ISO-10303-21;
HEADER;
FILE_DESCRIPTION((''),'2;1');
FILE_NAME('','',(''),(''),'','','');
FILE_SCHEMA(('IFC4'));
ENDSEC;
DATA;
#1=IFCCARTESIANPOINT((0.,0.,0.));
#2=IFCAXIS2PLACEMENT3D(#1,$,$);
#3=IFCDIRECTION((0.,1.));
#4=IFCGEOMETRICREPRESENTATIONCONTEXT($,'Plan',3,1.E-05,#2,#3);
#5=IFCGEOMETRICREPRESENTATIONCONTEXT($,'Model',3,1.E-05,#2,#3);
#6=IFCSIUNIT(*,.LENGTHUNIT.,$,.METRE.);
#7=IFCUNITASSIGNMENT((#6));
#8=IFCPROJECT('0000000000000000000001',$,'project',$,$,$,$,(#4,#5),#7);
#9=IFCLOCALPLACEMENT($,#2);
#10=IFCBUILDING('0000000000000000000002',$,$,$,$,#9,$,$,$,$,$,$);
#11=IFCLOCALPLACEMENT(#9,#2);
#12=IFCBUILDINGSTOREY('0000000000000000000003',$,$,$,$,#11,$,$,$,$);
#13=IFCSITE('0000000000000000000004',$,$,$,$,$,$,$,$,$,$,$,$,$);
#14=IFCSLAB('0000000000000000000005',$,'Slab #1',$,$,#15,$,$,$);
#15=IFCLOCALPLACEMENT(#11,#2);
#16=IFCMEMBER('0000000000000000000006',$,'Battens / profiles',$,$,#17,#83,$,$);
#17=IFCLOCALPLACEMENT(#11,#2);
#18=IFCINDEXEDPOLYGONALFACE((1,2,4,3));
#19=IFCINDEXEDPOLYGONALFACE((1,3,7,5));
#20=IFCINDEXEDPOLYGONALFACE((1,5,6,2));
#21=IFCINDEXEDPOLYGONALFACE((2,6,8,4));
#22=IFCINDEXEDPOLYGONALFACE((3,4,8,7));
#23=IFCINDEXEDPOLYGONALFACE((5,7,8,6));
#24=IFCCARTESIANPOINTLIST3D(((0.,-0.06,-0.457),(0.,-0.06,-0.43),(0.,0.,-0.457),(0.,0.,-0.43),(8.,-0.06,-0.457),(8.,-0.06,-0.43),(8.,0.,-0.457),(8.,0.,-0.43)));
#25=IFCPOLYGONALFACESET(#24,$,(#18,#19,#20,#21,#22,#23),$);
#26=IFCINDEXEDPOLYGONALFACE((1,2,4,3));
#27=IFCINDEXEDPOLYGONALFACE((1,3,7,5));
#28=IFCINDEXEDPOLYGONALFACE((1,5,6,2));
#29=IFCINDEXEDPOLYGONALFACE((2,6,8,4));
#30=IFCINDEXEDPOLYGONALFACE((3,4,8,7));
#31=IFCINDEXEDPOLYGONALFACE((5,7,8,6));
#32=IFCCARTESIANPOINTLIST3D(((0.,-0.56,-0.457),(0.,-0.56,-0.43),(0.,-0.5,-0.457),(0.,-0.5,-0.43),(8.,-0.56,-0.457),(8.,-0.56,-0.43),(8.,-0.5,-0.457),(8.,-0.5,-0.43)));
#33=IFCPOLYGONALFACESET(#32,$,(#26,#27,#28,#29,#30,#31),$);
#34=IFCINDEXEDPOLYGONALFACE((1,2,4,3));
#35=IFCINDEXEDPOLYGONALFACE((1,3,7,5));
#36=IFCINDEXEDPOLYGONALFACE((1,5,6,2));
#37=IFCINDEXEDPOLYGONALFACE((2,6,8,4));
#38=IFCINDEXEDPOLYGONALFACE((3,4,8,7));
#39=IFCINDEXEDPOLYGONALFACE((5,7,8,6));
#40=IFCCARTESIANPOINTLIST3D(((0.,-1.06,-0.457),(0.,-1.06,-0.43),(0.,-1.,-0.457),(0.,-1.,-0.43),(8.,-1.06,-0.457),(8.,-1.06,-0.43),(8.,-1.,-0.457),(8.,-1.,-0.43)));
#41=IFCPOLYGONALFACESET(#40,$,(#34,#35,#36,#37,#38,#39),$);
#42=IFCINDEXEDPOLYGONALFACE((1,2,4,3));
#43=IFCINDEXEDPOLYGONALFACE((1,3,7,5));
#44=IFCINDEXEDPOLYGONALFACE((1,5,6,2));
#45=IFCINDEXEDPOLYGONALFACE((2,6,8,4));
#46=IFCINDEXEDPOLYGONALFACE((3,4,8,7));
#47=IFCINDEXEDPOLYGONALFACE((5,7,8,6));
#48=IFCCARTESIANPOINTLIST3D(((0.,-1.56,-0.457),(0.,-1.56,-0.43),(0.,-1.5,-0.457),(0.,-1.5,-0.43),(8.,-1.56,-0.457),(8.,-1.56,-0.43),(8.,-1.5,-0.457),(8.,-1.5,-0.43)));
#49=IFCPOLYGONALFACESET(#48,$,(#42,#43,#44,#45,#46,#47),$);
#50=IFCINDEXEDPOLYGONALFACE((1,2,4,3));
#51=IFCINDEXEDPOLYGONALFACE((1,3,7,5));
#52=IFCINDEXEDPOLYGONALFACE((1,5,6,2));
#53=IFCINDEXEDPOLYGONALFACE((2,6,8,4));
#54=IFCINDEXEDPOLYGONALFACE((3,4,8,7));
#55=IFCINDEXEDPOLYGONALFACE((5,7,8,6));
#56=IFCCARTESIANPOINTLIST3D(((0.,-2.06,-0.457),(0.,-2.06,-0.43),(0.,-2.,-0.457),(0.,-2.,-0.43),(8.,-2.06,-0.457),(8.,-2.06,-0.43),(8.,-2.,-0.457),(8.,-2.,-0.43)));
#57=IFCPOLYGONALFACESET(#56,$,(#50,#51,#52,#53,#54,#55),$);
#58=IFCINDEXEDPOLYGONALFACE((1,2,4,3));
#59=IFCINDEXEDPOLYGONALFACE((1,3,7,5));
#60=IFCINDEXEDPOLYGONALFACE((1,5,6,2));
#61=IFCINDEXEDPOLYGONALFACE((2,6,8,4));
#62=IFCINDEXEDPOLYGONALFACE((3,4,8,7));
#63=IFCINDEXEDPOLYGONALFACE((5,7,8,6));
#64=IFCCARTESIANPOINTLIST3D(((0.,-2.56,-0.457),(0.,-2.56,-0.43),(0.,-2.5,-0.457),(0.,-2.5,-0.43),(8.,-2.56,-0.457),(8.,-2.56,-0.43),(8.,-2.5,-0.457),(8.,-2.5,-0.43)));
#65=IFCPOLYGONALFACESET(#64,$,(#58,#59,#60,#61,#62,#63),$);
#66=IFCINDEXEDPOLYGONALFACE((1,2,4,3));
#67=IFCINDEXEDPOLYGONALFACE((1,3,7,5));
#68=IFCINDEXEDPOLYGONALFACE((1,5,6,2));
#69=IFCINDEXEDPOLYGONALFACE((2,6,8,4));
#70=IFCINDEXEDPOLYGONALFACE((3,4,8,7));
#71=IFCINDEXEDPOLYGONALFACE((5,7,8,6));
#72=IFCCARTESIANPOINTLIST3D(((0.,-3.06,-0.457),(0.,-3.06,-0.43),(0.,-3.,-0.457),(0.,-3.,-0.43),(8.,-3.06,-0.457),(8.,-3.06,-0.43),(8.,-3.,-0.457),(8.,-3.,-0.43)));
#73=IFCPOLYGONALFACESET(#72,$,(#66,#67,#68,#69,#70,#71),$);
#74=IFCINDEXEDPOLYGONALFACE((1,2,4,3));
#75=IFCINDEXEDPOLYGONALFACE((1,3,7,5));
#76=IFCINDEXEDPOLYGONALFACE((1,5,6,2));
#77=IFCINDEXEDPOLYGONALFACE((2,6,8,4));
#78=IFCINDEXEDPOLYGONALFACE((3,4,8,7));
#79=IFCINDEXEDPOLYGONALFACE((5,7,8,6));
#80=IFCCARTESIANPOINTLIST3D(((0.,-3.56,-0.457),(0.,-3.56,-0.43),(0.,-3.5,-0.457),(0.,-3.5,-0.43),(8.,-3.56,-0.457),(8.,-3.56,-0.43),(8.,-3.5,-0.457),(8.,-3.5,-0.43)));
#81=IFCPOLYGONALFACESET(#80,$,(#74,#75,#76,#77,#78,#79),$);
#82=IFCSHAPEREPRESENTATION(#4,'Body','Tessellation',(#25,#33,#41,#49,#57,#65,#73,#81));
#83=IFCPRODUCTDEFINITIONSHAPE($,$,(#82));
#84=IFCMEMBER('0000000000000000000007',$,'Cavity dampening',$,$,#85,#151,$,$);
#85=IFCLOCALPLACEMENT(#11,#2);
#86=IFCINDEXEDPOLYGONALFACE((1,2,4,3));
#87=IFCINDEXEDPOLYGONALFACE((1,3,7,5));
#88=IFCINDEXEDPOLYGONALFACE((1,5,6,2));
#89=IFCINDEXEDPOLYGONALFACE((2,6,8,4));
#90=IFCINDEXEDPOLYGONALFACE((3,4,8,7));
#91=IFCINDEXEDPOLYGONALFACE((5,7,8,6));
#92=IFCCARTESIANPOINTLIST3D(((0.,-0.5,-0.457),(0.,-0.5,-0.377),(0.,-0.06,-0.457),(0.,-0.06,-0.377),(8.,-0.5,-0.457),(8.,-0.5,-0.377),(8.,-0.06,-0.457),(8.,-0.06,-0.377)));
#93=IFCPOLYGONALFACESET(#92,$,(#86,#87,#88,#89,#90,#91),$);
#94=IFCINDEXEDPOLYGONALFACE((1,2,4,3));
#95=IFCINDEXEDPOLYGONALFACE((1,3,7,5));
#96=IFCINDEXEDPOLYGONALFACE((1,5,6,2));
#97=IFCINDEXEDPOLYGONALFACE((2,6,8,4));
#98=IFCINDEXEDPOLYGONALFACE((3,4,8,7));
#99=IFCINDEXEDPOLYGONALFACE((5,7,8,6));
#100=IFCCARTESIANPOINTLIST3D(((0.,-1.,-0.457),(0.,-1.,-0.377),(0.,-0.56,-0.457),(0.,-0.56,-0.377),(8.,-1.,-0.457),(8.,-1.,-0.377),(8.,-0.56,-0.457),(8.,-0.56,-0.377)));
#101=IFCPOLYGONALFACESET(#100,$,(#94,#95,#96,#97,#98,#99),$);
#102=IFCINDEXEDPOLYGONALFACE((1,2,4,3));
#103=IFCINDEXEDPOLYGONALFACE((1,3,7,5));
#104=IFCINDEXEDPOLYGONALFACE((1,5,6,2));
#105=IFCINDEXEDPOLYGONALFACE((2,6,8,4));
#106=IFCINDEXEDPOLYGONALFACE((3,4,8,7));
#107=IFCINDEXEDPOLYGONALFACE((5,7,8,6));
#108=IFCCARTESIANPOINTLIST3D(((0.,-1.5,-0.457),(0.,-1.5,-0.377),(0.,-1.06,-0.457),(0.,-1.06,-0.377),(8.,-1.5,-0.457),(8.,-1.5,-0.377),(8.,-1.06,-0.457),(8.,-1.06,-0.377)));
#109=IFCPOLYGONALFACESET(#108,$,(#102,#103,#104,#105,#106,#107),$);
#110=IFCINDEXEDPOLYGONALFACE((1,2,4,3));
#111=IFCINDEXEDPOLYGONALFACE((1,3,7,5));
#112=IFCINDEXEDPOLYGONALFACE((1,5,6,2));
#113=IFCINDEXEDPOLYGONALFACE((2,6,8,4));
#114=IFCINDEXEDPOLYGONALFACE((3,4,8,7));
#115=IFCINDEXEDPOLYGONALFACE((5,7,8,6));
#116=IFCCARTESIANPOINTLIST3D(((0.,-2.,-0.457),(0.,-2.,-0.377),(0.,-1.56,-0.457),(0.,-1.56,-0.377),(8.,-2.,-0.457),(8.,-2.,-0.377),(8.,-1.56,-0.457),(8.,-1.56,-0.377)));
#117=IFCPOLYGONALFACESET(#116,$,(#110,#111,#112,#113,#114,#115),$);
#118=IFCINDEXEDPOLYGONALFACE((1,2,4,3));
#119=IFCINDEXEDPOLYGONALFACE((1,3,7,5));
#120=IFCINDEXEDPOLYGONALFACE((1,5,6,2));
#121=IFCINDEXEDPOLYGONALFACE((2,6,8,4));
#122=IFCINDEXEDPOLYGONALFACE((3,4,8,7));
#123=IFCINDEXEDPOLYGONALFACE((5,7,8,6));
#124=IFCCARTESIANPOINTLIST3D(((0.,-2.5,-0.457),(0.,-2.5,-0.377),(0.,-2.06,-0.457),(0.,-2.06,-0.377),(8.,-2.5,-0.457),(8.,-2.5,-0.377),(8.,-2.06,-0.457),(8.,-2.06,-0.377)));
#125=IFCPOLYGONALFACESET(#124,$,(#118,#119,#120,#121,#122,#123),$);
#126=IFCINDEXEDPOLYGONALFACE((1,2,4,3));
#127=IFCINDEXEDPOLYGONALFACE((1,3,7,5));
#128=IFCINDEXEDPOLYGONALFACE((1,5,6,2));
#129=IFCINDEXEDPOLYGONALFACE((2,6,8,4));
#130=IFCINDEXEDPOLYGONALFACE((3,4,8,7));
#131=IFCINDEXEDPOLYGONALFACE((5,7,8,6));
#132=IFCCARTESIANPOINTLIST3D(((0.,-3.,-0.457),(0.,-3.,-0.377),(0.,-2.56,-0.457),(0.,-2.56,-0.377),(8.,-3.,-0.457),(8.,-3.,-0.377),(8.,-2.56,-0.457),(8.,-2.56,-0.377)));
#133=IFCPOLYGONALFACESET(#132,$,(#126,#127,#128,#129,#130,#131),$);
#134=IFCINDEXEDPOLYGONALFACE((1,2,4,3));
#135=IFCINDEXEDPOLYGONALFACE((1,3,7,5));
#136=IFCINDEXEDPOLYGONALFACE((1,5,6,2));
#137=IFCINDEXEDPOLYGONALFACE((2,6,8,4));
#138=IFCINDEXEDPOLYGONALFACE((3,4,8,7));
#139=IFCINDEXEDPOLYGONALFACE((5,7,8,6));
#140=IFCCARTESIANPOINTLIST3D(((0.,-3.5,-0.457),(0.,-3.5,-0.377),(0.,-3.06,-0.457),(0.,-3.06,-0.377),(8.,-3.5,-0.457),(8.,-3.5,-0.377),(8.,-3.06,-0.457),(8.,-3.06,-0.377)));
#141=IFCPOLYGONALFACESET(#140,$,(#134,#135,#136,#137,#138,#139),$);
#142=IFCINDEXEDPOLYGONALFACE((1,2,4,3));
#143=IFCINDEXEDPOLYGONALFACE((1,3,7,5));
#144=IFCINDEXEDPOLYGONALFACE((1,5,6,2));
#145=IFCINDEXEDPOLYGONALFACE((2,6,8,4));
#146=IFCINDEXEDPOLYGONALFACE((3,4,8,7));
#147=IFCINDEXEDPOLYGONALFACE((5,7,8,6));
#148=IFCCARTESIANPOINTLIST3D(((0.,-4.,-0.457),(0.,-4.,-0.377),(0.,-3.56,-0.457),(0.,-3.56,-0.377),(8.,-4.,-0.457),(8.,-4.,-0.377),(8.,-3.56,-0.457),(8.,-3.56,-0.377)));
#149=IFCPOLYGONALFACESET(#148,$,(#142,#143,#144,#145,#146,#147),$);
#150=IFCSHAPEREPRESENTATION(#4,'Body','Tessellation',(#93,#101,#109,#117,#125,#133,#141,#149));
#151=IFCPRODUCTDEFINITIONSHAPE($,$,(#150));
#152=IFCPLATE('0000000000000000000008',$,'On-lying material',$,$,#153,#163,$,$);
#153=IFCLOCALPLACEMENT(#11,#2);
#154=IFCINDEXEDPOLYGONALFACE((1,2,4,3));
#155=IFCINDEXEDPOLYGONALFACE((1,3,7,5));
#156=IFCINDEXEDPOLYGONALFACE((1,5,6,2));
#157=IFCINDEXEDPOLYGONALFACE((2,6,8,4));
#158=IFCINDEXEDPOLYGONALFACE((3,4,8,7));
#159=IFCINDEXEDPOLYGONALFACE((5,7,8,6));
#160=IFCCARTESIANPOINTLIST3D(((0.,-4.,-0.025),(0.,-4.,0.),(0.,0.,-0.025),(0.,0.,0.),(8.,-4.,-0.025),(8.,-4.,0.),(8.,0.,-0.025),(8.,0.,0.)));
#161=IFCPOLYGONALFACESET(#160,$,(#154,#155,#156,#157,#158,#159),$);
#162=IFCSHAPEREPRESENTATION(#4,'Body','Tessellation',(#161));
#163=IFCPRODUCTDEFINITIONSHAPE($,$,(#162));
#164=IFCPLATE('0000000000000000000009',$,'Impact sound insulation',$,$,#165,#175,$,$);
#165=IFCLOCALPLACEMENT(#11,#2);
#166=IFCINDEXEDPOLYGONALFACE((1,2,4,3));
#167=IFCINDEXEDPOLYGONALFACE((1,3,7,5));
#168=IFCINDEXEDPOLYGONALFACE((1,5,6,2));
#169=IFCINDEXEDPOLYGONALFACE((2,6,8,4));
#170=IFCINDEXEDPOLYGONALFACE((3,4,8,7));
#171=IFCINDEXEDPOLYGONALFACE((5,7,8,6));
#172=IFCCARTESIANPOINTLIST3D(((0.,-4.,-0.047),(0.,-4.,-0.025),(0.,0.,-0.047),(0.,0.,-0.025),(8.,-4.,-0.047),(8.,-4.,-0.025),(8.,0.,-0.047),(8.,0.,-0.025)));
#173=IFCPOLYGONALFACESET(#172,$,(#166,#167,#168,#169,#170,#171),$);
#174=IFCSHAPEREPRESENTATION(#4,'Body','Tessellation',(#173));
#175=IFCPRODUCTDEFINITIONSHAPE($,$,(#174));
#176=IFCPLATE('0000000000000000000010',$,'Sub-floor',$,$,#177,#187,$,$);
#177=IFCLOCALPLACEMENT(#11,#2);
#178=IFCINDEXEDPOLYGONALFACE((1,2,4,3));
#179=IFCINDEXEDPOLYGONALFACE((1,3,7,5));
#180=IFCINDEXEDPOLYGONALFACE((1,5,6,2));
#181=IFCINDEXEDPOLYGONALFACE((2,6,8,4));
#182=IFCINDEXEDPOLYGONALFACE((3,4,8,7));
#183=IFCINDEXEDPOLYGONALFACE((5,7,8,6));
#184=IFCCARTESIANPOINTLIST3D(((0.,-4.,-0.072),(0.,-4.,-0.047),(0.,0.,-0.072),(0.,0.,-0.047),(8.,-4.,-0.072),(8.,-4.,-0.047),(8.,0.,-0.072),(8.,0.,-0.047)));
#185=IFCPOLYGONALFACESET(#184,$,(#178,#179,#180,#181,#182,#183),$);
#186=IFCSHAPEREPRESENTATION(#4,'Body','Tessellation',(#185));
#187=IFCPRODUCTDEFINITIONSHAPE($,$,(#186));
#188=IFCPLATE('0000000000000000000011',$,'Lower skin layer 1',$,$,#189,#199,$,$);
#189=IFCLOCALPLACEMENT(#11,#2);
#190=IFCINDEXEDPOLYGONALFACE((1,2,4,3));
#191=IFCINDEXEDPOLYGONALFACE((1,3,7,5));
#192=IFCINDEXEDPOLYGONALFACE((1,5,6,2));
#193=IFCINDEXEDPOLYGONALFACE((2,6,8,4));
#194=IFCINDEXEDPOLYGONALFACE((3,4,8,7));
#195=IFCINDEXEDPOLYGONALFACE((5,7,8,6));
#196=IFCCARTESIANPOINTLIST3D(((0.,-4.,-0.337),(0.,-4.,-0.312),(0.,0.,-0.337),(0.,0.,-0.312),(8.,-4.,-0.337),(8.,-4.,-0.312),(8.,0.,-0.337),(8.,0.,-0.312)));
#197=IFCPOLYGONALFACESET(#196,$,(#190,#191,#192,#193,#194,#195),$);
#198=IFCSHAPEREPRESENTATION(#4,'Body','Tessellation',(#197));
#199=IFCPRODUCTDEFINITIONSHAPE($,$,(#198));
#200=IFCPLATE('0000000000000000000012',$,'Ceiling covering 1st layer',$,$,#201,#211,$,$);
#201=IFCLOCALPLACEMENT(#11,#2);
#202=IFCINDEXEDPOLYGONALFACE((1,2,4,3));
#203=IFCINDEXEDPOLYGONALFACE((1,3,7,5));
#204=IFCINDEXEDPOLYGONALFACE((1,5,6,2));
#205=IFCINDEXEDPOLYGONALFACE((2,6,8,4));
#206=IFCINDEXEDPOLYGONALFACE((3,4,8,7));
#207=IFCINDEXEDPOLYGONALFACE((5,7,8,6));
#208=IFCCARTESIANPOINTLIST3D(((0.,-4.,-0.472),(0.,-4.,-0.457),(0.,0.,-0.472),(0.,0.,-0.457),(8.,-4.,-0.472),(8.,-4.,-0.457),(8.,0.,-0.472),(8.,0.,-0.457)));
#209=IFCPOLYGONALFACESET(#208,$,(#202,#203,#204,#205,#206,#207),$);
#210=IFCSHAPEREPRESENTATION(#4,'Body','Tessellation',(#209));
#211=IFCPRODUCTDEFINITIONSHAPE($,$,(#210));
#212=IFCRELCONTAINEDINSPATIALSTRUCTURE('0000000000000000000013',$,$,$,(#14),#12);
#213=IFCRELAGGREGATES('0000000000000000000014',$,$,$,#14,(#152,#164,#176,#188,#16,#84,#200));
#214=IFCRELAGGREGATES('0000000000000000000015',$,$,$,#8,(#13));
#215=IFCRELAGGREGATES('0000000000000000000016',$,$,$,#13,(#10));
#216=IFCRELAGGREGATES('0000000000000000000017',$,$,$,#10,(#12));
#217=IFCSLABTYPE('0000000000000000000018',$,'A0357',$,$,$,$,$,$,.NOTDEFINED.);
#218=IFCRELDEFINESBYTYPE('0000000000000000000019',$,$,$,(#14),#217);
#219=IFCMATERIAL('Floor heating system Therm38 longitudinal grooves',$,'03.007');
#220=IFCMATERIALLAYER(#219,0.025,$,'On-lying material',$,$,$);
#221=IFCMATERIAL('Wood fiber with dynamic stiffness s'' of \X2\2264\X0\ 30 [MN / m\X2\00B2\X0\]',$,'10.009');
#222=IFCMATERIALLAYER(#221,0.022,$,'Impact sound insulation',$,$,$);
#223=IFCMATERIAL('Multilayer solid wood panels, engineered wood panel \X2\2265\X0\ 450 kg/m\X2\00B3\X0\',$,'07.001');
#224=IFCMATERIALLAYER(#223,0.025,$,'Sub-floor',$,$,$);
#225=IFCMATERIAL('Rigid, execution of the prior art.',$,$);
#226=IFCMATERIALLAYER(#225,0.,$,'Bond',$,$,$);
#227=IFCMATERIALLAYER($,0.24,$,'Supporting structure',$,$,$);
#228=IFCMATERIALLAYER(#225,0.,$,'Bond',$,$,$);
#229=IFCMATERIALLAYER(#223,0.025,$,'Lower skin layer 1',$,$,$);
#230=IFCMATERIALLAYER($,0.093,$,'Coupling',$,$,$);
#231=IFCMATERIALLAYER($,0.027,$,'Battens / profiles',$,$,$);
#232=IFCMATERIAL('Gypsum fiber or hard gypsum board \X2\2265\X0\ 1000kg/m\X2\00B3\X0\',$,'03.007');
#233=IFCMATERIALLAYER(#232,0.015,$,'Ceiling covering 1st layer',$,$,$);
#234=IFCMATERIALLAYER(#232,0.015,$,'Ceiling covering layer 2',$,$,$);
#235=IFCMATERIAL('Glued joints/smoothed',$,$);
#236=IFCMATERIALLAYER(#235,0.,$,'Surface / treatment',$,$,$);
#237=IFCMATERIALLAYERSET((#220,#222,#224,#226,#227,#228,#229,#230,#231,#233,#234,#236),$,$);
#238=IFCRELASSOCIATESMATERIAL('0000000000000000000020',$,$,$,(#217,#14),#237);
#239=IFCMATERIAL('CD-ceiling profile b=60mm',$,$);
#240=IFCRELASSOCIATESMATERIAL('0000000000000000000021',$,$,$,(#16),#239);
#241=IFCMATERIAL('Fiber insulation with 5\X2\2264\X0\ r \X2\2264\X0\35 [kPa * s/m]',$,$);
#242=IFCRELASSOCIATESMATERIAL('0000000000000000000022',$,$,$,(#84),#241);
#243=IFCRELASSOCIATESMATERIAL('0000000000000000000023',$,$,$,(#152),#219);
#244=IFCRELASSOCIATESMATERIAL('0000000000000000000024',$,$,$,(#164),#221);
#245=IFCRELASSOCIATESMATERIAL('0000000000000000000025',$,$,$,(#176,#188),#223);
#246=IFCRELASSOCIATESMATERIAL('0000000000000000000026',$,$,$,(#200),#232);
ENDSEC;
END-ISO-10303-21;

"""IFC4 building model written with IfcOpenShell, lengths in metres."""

from ifc_helpers import new_model, si_unit, direction, frame, frame_2d, origin, origin_with_axes, place, context, project, spatial, rectangle, extrude, material, layer, layer_set, type_object, element, aggregate, save


model = new_model("IFC4")

# Units and contexts
plan_context = context("Plan", 3, precision=1e-05, world=origin(), true_north=direction((0.0, 1.0)))
model_context = context("Model", 3, precision=1e-05, world=origin(), true_north=direction((0.0, 1.0)))
ifc_project = project(units=[si_unit("LENGTHUNIT", "METRE")], contexts=[plan_context, model_context])

# Site, building, storey
site = spatial("IfcSite", under=ifc_project)
building_placement = place(None, origin())
building = spatial("IfcBuilding", under=site, at=building_placement)
storey_placement = place(building_placement, origin())
storey = spatial("IfcBuildingStorey", under=building, at=storey_placement)

# Slab, members, plates
ifc_material_1 = material(Name="Floor heating system Therm38 longitudinal grooves", Category="03.007")
ifc_layer_1 = layer(ifc_material_1, 0.025, Name="On-lying material")
ifc_material_2 = material(Name="Wood fiber with dynamic stiffness s' of ≤ 30 [MN / m²]", Category="10.009")
ifc_layer_2 = layer(ifc_material_2, 0.022, Name="Impact sound insulation")
ifc_material_3 = material(Name="Multilayer solid wood panels, engineered wood panel ≥ 450 kg/m³", Category="07.001")
ifc_layer_3 = layer(ifc_material_3, 0.025, Name="Sub-floor")
ifc_material_4 = material(Name="Rigid, execution of the prior art.")
ifc_layer_4 = layer(ifc_material_4, 0.0, Name="Bond")
ifc_layer_5 = layer(None, 0.24, Name="Supporting structure")
ifc_layer_6 = layer(ifc_material_4, 0.0, Name="Bond")
ifc_layer_7 = layer(ifc_material_3, 0.025, Name="Lower skin layer 1")
ifc_layer_8 = layer(None, 0.093, Name="Coupling")
ifc_layer_9 = layer(None, 0.027, Name="Battens / profiles")
ifc_material_5 = material(Name="Gypsum fiber or hard gypsum board ≥ 1000kg/m³", Category="03.007")
ifc_layer_10 = layer(ifc_material_5, 0.015, Name="Ceiling covering 1st layer")
ifc_layer_11 = layer(ifc_material_5, 0.015, Name="Ceiling covering layer 2")
ifc_material_6 = material(Name="Glued joints/smoothed")
ifc_layer_12 = layer(ifc_material_6, 0.0, Name="Surface / treatment")
ifc_layer_set = layer_set([ifc_layer_1, ifc_layer_2, ifc_layer_3, ifc_layer_4, ifc_layer_5, ifc_layer_6, ifc_layer_7, ifc_layer_8, ifc_layer_9, ifc_layer_10, ifc_layer_11, ifc_layer_12])
slab_type = type_object("IfcSlabType", Name="A0357", PredefinedType="NOTDEFINED", material=ifc_layer_set)
slab_placement = place(None, frame((0.0, 0.0, 0.0), z_axis=(0.0, 0.0, -1.0), x_axis=(1.0, 0.0, 0.0)))
slab = element("IfcSlab", 1, at=slab_placement, inside=storey, type_object=slab_type, material=ifc_layer_set, Name="Slab #1")
ifc_material_7 = material(Name="Fiber insulation with 5≤ r ≤35 [kPa * s/m]")
ifc_material_8 = material(Name="CD-ceiling profile b=60mm")
member_1_placement = place(slab_placement, origin())
member_1 = element("IfcMember", 2, at=member_1_placement, material=ifc_material_8, Name="Battens / profiles", context=plan_context, shape_type="SweptSolid", body=[
    extrude(rectangle(XDim=0.06, YDim=0.027, at=frame_2d((0.03, 0.0135), x_axis=(1.0, 0.0))), frame((0.0, 0.0, 0.43), z_axis=(1.0, 0.0, 0.0), x_axis=(0.0, 1.0, 0.0)), (0.0, 0.0, 1.0), 8.0),
    extrude(rectangle(XDim=0.06, YDim=0.027, at=frame_2d((0.03, 0.0135), x_axis=(1.0, 0.0))), frame((0.0, 0.5, 0.43), z_axis=(1.0, 0.0, 0.0), x_axis=(0.0, 1.0, 0.0)), (0.0, 0.0, 1.0), 8.0),
    extrude(rectangle(XDim=0.06, YDim=0.027, at=frame_2d((0.03, 0.0135), x_axis=(1.0, 0.0))), frame((0.0, 1.0, 0.43), z_axis=(1.0, 0.0, 0.0), x_axis=(0.0, 1.0, 0.0)), (0.0, 0.0, 1.0), 8.0),
    extrude(rectangle(XDim=0.06, YDim=0.027, at=frame_2d((0.03, 0.0135), x_axis=(1.0, 0.0))), frame((0.0, 1.5, 0.43), z_axis=(1.0, 0.0, 0.0), x_axis=(0.0, 1.0, 0.0)), (0.0, 0.0, 1.0), 8.0),
    extrude(rectangle(XDim=0.06, YDim=0.027, at=frame_2d((0.03, 0.0135), x_axis=(1.0, 0.0))), frame((0.0, 2.0, 0.43), z_axis=(1.0, 0.0, 0.0), x_axis=(0.0, 1.0, 0.0)), (0.0, 0.0, 1.0), 8.0),
    extrude(rectangle(XDim=0.06, YDim=0.027, at=frame_2d((0.03, 0.0135), x_axis=(1.0, 0.0))), frame((0.0, 2.5, 0.43), z_axis=(1.0, 0.0, 0.0), x_axis=(0.0, 1.0, 0.0)), (0.0, 0.0, 1.0), 8.0),
    extrude(rectangle(XDim=0.06, YDim=0.027, at=frame_2d((0.03, 0.0135), x_axis=(1.0, 0.0))), frame((0.0, 3.0, 0.43), z_axis=(1.0, 0.0, 0.0), x_axis=(0.0, 1.0, 0.0)), (0.0, 0.0, 1.0), 8.0),
    extrude(rectangle(XDim=0.06, YDim=0.027, at=frame_2d((0.03, 0.0135), x_axis=(1.0, 0.0))), frame((0.0, 3.5, 0.43), z_axis=(1.0, 0.0, 0.0), x_axis=(0.0, 1.0, 0.0)), (0.0, 0.0, 1.0), 8.0),
])
member_2_placement = place(slab_placement, origin())
member_2 = element("IfcMember", 3, at=member_2_placement, material=ifc_material_7, Name="Cavity dampening", context=plan_context, shape_type="SweptSolid", body=[
    extrude(rectangle(XDim=0.44, YDim=0.08, at=frame_2d((0.22, 0.04), x_axis=(1.0, 0.0))), frame((0.0, 0.06, 0.377), z_axis=(1.0, 0.0, 0.0), x_axis=(0.0, 1.0, 0.0)), (0.0, 0.0, 1.0), 8.0),
    extrude(rectangle(XDim=0.44, YDim=0.08, at=frame_2d((0.22, 0.04), x_axis=(1.0, 0.0))), frame((0.0, 0.56, 0.377), z_axis=(1.0, 0.0, 0.0), x_axis=(0.0, 1.0, 0.0)), (0.0, 0.0, 1.0), 8.0),
    extrude(rectangle(XDim=0.44, YDim=0.08, at=frame_2d((0.22, 0.04), x_axis=(1.0, 0.0))), frame((0.0, 1.06, 0.377), z_axis=(1.0, 0.0, 0.0), x_axis=(0.0, 1.0, 0.0)), (0.0, 0.0, 1.0), 8.0),
    extrude(rectangle(XDim=0.44, YDim=0.08, at=frame_2d((0.22, 0.04), x_axis=(1.0, 0.0))), frame((0.0, 1.56, 0.377), z_axis=(1.0, 0.0, 0.0), x_axis=(0.0, 1.0, 0.0)), (0.0, 0.0, 1.0), 8.0),
    extrude(rectangle(XDim=0.44, YDim=0.08, at=frame_2d((0.22, 0.04), x_axis=(1.0, 0.0))), frame((0.0, 2.06, 0.377), z_axis=(1.0, 0.0, 0.0), x_axis=(0.0, 1.0, 0.0)), (0.0, 0.0, 1.0), 8.0),
    extrude(rectangle(XDim=0.44, YDim=0.08, at=frame_2d((0.22, 0.04), x_axis=(1.0, 0.0))), frame((0.0, 2.56, 0.377), z_axis=(1.0, 0.0, 0.0), x_axis=(0.0, 1.0, 0.0)), (0.0, 0.0, 1.0), 8.0),
    extrude(rectangle(XDim=0.44, YDim=0.08, at=frame_2d((0.22, 0.04), x_axis=(1.0, 0.0))), frame((0.0, 3.06, 0.377), z_axis=(1.0, 0.0, 0.0), x_axis=(0.0, 1.0, 0.0)), (0.0, 0.0, 1.0), 8.0),
    extrude(rectangle(XDim=0.44, YDim=0.08, at=frame_2d((0.22, 0.04), x_axis=(1.0, 0.0))), frame((0.0, 3.56, 0.377), z_axis=(1.0, 0.0, 0.0), x_axis=(0.0, 1.0, 0.0)), (0.0, 0.0, 1.0), 8.0),
])
plate_1_placement = place(slab_placement, origin())
plate_1 = element("IfcPlate", 4, at=plate_1_placement, material=ifc_material_1, Name="On-lying material", context=plan_context, shape_type="SweptSolid", body=[
    extrude(rectangle(XDim=8.0, YDim=4.0, at=frame_2d((4.0, 2.0), x_axis=(1.0, 0.0))), origin_with_axes(), (0.0, 0.0, 1.0), 0.025),
])
plate_2_placement = place(slab_placement, origin())
plate_2 = element("IfcPlate", 5, at=plate_2_placement, material=ifc_material_2, Name="Impact sound insulation", context=plan_context, shape_type="SweptSolid", body=[
    extrude(rectangle(XDim=8.0, YDim=4.0, at=frame_2d((4.0, 2.0), x_axis=(1.0, 0.0))), frame((0.0, 0.0, 0.025), z_axis=(0.0, 0.0, 1.0), x_axis=(1.0, 0.0, 0.0)), (0.0, 0.0, 1.0), 0.022),
])
plate_3_placement = place(slab_placement, origin())
plate_3 = element("IfcPlate", 6, at=plate_3_placement, material=ifc_material_3, Name="Sub-floor", context=plan_context, shape_type="SweptSolid", body=[
    extrude(rectangle(XDim=8.0, YDim=4.0, at=frame_2d((4.0, 2.0), x_axis=(1.0, 0.0))), frame((0.0, 0.0, 0.047), z_axis=(0.0, 0.0, 1.0), x_axis=(1.0, 0.0, 0.0)), (0.0, 0.0, 1.0), 0.025),
])
plate_4_placement = place(slab_placement, origin())
plate_4 = element("IfcPlate", 7, at=plate_4_placement, material=ifc_material_3, Name="Lower skin layer 1", context=plan_context, shape_type="SweptSolid", body=[
    extrude(rectangle(XDim=8.0, YDim=4.0, at=frame_2d((4.0, 2.0), x_axis=(1.0, 0.0))), frame((0.0, 0.0, 0.312), z_axis=(0.0, 0.0, 1.0), x_axis=(1.0, 0.0, 0.0)), (0.0, 0.0, 1.0), 0.025),
])
plate_5_placement = place(slab_placement, origin())
plate_5 = element("IfcPlate", 8, at=plate_5_placement, material=ifc_material_5, Name="Ceiling covering 1st layer", context=plan_context, shape_type="SweptSolid", body=[
    extrude(rectangle(XDim=8.0, YDim=4.0, at=frame_2d((4.0, 2.0), x_axis=(1.0, 0.0))), frame((0.0, 0.0, 0.457), z_axis=(0.0, 0.0, 1.0), x_axis=(1.0, 0.0, 0.0)), (0.0, 0.0, 1.0), 0.015),
])
aggregate(slab, [plate_1, plate_2, plate_3, plate_4, member_1, member_2, plate_5])

save(model, "model.ifc")
